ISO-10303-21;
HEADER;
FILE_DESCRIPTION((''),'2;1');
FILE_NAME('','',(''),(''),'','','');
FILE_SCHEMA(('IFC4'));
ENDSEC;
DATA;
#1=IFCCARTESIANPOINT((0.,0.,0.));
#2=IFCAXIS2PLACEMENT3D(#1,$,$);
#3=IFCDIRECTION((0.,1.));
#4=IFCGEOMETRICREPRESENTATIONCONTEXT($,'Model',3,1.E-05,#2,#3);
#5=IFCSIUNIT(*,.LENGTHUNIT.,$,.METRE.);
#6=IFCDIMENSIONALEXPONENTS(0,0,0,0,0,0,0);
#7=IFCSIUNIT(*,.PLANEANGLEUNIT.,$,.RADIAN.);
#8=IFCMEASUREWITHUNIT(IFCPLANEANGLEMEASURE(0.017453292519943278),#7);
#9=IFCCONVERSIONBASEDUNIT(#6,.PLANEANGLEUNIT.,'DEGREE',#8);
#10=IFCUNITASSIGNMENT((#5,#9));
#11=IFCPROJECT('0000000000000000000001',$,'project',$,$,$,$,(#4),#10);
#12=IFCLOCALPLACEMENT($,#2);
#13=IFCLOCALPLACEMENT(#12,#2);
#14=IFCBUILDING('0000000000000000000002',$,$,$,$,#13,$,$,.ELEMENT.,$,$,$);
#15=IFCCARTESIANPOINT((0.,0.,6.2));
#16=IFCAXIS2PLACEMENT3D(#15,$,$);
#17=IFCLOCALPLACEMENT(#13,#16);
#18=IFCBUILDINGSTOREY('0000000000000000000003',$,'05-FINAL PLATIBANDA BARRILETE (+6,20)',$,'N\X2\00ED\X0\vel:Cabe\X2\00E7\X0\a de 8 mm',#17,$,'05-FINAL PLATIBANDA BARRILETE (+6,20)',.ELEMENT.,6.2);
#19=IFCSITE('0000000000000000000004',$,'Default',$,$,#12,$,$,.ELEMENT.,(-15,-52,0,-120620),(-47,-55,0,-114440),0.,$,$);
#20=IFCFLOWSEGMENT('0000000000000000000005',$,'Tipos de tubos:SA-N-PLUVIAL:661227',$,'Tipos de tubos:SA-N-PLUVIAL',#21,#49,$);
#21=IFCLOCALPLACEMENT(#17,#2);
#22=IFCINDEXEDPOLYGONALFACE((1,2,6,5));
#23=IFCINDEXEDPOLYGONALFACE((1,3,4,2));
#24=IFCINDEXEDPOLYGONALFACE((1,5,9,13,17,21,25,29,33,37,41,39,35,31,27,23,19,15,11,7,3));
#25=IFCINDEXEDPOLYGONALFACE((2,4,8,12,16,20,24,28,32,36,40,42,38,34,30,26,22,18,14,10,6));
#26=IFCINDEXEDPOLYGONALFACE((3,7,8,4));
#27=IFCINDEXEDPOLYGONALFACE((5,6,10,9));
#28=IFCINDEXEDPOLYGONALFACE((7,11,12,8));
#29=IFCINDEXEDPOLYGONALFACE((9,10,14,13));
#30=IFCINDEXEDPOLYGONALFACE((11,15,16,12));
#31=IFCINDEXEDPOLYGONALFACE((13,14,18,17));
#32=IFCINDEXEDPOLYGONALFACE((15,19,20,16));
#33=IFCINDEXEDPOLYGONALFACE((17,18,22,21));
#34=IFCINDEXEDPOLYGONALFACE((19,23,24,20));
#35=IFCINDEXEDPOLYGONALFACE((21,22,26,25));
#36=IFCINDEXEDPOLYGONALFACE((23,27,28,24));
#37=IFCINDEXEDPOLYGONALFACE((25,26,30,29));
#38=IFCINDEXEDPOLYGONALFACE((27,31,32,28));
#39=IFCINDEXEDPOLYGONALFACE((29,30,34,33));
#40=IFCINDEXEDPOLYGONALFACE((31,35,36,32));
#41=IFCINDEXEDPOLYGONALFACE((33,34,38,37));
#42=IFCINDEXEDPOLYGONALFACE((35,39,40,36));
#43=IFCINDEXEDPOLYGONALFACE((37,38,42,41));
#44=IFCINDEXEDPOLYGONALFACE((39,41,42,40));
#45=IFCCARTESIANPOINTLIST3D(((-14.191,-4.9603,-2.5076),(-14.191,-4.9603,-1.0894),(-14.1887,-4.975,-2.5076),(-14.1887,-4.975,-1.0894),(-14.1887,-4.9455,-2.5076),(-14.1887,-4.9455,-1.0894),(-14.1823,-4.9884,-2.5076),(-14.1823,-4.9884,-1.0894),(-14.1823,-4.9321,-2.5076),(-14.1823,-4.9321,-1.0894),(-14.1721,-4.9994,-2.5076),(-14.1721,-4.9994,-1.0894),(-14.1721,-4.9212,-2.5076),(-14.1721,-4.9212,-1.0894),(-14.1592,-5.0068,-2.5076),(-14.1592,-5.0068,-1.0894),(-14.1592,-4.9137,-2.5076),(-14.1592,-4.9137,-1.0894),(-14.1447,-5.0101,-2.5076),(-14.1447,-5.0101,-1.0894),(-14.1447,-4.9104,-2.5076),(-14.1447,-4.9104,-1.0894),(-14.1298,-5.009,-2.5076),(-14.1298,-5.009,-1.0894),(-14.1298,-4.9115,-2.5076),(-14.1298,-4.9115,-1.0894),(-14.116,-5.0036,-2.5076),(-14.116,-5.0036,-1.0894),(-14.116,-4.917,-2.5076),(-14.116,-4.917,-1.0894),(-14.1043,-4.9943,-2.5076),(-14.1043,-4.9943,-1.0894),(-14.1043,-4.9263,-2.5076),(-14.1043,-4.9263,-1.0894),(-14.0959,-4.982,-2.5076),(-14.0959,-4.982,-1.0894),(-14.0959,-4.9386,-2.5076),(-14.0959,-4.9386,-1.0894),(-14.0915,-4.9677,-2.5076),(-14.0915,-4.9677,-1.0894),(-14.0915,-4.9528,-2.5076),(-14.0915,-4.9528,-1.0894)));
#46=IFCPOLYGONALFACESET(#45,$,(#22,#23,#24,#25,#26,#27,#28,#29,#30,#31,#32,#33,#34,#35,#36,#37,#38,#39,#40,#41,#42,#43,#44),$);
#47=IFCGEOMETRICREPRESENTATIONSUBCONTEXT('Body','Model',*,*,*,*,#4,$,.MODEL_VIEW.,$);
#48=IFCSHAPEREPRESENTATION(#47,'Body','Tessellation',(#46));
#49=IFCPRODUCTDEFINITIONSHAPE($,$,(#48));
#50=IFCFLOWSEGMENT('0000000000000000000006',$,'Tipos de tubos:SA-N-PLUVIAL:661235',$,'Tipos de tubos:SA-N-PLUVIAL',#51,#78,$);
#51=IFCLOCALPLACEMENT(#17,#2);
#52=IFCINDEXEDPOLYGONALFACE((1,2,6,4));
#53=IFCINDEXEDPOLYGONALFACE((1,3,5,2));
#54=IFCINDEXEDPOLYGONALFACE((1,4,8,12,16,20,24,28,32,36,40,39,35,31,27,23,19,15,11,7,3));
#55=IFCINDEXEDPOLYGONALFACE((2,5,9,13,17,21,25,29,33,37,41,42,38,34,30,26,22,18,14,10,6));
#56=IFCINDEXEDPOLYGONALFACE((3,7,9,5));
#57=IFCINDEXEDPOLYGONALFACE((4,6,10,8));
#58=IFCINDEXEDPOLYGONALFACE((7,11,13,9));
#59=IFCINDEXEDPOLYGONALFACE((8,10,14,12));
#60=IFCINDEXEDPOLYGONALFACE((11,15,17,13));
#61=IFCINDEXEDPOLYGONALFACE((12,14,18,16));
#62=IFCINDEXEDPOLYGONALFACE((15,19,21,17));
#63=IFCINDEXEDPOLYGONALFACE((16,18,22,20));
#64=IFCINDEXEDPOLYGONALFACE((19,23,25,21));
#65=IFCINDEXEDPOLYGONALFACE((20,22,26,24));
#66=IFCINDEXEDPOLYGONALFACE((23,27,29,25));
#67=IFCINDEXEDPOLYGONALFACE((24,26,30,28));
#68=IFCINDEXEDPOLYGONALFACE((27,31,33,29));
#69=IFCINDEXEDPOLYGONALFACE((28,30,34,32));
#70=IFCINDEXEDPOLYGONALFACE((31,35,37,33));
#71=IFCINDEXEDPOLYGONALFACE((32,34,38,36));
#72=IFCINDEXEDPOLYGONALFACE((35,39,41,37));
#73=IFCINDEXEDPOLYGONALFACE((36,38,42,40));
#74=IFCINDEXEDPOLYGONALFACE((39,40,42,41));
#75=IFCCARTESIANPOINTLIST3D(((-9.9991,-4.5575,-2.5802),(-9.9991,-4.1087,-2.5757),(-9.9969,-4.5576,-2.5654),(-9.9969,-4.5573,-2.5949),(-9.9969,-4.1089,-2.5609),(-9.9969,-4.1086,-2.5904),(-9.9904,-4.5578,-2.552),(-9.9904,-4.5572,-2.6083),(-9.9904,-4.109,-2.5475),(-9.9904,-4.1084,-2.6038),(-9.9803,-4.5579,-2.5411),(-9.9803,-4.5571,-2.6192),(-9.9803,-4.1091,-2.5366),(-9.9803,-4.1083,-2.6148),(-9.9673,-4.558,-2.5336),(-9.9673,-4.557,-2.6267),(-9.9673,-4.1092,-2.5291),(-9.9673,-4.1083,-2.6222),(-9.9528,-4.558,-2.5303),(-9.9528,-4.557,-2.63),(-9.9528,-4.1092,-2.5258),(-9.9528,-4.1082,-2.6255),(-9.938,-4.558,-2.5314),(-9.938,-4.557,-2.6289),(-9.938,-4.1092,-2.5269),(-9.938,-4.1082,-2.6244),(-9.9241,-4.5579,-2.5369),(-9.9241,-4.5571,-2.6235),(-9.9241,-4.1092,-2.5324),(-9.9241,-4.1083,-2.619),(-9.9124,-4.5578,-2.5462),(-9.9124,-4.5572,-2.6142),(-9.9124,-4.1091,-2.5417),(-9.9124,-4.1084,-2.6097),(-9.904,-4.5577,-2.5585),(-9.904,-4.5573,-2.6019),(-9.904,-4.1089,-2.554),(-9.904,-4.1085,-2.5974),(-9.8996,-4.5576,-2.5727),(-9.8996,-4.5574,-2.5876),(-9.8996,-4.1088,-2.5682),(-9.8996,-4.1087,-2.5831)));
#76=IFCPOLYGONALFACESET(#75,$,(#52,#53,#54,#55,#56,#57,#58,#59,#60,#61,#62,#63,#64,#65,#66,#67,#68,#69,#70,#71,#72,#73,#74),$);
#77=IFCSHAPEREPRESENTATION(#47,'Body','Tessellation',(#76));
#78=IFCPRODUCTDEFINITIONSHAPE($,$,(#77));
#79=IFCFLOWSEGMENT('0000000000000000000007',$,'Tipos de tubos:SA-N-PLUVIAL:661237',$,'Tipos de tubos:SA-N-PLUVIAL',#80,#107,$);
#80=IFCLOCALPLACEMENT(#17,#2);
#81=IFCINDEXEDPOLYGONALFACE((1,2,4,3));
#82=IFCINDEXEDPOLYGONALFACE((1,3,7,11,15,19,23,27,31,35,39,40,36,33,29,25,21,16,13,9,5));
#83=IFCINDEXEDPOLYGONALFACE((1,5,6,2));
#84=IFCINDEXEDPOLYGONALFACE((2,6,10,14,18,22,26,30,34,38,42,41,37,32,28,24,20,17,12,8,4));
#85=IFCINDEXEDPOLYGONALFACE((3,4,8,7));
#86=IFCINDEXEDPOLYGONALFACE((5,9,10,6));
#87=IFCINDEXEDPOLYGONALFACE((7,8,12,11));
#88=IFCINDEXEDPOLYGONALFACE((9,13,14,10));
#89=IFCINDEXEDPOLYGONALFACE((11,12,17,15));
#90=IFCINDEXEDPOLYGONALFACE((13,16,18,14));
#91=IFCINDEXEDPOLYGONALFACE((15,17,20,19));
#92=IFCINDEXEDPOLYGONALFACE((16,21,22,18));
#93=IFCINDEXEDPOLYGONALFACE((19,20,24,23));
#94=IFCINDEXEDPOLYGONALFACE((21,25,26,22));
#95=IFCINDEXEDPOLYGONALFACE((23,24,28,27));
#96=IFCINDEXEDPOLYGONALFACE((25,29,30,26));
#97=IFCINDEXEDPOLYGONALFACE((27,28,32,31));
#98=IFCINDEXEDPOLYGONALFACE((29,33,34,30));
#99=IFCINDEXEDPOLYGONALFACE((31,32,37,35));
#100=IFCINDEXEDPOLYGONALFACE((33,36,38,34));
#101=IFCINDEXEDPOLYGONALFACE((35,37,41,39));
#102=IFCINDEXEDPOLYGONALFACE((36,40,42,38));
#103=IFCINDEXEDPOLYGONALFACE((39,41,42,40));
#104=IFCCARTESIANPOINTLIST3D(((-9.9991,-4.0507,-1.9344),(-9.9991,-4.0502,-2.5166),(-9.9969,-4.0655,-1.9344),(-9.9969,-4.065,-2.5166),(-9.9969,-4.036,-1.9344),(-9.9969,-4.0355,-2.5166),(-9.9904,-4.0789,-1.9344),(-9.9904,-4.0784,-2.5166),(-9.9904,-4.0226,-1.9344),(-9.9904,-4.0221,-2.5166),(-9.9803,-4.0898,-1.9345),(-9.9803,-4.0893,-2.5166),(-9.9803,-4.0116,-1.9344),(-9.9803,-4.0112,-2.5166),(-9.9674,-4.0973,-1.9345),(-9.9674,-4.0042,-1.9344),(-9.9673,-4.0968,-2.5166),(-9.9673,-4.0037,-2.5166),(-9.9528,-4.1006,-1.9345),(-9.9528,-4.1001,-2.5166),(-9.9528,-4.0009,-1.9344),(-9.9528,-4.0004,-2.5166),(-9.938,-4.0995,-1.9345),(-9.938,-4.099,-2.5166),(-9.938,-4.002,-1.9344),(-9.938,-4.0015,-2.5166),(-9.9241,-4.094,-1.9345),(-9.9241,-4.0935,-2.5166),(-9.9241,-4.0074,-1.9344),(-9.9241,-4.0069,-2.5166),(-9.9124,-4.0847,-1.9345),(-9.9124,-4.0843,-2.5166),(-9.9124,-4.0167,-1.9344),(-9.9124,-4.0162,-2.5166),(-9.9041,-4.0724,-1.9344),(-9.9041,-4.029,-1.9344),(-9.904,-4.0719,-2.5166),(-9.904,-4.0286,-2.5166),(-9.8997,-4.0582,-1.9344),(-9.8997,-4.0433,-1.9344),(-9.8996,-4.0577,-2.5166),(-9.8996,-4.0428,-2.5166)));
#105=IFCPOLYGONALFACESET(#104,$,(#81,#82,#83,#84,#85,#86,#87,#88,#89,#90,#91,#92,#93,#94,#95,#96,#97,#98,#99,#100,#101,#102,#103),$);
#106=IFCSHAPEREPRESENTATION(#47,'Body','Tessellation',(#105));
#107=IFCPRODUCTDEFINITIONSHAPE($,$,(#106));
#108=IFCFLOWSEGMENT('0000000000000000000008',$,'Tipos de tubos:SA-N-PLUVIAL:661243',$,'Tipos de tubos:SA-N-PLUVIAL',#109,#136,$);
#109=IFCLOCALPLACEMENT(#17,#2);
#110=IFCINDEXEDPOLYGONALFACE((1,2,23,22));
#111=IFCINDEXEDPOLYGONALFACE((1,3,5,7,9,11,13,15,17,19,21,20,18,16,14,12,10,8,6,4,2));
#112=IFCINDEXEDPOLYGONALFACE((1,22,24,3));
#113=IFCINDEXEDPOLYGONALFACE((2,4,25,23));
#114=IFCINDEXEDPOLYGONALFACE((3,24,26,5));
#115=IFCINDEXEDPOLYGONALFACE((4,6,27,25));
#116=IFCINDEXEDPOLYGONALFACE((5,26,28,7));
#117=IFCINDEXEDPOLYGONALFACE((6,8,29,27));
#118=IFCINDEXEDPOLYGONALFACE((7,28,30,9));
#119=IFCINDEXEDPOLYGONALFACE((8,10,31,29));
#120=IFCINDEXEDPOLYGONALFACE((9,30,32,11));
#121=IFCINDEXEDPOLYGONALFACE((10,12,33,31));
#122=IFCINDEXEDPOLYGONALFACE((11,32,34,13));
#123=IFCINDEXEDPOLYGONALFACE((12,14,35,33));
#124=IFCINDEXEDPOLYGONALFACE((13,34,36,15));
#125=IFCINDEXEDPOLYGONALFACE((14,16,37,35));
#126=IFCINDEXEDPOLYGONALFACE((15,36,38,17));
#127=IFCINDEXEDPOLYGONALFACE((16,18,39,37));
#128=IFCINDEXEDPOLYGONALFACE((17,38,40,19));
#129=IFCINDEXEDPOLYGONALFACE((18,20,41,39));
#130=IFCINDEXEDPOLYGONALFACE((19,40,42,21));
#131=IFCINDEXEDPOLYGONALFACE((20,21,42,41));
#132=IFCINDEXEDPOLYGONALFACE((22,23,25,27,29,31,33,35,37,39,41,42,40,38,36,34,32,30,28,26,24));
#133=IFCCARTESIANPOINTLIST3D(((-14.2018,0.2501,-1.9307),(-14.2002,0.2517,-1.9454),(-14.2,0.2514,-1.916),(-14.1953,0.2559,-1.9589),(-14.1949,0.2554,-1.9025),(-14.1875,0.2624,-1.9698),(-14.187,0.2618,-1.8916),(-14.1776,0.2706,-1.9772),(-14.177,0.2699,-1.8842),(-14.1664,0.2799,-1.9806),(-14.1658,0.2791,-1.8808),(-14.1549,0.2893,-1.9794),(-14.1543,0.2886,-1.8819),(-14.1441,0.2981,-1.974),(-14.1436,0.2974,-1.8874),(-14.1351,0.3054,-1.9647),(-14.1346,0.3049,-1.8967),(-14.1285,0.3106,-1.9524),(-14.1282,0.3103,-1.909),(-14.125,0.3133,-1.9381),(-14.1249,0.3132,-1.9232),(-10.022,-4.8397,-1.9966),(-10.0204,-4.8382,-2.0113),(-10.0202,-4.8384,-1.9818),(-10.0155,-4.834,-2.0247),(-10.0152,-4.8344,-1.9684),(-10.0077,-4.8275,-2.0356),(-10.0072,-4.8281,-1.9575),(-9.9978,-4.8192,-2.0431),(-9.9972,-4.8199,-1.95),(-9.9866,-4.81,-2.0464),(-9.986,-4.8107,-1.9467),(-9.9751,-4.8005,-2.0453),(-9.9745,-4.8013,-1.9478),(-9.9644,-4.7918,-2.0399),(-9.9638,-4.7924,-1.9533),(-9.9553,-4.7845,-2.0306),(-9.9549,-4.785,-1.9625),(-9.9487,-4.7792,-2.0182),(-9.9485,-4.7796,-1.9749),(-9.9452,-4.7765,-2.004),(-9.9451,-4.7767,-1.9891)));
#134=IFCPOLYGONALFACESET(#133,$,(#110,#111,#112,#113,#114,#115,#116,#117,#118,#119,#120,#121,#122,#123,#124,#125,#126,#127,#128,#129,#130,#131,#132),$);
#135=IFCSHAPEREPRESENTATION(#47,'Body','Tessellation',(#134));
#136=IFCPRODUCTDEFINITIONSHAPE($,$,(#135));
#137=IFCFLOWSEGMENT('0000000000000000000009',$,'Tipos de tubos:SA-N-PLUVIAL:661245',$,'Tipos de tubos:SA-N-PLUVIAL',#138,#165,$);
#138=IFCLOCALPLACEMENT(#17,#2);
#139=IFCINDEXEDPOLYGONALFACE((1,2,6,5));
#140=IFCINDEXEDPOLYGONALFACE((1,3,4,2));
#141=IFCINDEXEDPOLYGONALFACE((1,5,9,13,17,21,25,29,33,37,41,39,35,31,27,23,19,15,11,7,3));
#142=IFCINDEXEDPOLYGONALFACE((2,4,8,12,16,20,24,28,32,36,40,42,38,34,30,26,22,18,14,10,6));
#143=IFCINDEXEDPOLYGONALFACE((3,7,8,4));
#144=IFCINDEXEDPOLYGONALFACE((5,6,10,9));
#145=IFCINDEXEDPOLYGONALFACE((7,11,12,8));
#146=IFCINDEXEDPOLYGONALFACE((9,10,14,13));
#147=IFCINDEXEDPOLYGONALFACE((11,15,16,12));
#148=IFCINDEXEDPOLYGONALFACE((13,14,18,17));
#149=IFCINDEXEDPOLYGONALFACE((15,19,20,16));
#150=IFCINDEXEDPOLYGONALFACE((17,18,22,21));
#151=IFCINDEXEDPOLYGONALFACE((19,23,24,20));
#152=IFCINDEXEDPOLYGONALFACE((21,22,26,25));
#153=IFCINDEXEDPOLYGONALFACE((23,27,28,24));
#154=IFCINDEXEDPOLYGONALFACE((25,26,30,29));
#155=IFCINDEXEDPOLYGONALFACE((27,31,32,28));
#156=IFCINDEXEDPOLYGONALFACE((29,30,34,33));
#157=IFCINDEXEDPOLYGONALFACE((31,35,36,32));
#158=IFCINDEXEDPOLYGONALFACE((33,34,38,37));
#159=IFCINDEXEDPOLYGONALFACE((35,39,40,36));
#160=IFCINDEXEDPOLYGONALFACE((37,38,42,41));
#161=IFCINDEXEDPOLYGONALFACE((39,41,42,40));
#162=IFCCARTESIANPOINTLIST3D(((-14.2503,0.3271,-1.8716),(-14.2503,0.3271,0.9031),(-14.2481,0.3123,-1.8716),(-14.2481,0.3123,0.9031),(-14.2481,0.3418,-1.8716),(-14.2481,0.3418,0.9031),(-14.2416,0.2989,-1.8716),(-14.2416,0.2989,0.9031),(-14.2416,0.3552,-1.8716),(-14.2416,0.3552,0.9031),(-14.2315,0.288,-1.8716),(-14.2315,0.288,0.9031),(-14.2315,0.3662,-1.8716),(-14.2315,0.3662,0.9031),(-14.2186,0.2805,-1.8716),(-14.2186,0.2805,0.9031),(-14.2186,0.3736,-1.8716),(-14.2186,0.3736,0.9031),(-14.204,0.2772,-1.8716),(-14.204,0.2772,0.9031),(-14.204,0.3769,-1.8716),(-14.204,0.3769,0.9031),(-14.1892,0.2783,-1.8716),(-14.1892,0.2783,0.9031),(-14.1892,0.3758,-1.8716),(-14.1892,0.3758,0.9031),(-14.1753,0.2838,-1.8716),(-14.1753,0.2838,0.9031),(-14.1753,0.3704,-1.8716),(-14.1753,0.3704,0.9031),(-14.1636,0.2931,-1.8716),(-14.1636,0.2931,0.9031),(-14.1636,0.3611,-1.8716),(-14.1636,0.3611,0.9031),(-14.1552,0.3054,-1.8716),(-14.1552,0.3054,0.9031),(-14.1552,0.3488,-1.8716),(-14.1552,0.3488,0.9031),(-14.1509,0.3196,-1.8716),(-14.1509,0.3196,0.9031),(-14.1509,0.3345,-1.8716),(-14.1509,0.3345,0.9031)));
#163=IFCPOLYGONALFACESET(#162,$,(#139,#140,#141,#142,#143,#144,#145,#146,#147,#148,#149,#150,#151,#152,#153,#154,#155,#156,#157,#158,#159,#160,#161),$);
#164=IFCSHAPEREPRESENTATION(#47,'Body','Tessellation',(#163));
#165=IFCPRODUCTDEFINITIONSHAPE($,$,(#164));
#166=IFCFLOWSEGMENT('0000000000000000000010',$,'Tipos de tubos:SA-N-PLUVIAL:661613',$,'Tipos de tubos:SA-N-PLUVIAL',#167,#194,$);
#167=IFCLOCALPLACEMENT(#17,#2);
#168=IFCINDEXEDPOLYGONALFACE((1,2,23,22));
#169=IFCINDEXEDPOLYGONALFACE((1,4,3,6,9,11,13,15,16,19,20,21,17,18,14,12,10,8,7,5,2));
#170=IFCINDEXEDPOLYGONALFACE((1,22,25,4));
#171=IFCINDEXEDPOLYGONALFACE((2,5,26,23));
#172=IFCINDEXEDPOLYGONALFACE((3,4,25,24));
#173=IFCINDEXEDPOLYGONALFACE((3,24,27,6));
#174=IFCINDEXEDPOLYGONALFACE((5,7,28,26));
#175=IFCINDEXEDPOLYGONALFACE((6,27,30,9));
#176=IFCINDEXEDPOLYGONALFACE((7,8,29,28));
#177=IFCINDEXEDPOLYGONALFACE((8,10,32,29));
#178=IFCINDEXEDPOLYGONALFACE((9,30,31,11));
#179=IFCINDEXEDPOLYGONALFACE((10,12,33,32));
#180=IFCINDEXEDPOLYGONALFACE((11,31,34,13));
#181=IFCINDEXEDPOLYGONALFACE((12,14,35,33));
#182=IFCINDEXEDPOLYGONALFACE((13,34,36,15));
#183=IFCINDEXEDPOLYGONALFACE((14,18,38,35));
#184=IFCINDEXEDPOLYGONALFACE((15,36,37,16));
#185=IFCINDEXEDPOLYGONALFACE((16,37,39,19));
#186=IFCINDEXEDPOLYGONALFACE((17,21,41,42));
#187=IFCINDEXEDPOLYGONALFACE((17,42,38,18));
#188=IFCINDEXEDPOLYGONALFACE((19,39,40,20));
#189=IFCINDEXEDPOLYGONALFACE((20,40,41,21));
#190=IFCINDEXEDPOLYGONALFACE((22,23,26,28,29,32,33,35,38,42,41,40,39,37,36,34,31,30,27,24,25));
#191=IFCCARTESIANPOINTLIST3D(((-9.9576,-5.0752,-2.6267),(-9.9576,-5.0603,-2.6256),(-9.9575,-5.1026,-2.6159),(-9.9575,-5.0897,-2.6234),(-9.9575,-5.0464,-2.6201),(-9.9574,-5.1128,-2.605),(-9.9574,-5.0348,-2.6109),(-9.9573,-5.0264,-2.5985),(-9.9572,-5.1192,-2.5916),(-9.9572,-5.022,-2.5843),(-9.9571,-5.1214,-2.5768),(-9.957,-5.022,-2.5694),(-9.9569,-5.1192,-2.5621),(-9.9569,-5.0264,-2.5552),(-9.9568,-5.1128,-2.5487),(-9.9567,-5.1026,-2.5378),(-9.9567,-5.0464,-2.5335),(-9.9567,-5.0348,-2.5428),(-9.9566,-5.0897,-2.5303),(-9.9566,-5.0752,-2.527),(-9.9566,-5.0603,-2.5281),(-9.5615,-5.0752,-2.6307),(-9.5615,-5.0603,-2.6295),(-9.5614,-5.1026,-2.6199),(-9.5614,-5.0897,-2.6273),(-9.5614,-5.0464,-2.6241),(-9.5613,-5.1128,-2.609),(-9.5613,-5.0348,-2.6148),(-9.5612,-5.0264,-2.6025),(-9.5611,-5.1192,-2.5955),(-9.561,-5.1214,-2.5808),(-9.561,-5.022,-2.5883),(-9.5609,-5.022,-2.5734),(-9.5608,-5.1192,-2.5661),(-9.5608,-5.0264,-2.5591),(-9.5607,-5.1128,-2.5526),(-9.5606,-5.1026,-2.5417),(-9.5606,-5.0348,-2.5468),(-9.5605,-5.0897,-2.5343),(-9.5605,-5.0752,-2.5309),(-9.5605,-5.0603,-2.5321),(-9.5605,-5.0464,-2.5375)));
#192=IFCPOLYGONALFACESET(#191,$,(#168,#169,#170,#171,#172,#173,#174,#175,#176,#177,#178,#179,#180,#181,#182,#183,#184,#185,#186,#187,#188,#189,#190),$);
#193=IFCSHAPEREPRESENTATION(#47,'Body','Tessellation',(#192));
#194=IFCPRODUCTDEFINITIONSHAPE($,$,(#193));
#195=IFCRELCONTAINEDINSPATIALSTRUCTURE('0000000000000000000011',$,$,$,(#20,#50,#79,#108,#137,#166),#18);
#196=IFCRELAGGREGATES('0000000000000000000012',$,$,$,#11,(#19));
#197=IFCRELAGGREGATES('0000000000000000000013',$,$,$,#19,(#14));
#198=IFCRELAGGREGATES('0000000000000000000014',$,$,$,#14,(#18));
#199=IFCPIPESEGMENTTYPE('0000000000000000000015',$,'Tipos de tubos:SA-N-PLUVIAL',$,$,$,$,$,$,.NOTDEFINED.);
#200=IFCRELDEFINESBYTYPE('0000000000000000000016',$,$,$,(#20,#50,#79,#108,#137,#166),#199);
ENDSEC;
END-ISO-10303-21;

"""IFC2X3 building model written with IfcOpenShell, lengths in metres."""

from ifc_helpers import new_model, entity, si_unit, converted_unit, direction, frame, frame_2d, origin, origin_2d_with_axis, place, context, subcontext, project, spatial, circle, extrude, type_object, element, save


model = new_model("IFC2X3")

# Units and contexts
model_context = context("Model", 3, precision=1e-05, world=origin(), true_north=direction((0.0, 1.0)))
body_context = subcontext(model_context, "Body", "Model", "MODEL_VIEW")
ifc_project = project(units=[si_unit("LENGTHUNIT", "METRE"), converted_unit("PLANEANGLEUNIT", "DEGREE", entity("IfcPlaneAngleMeasure", 0.017453292519943278), si_unit("PLANEANGLEUNIT", "RADIAN"), dimensions=[0, 0, 0, 0, 0, 0, 0])], contexts=[model_context])

# Site, building, storey
site_placement = place(None, origin())
site = spatial("IfcSite", under=ifc_project, at=site_placement, Name="Default", CompositionType="ELEMENT", RefLatitude=(-15, -52, 0, -120620), RefLongitude=(-47, -55, 0, -114440), RefElevation=0.0)
building_placement = place(site_placement, origin())
building = spatial("IfcBuilding", under=site, at=building_placement, CompositionType="ELEMENT")
storey_placement = place(building_placement, frame((0.0, 0.0, 6.2)))
storey = spatial("IfcBuildingStorey", under=building, at=storey_placement, Name="05-FINAL PLATIBANDA BARRILETE (+6,20)", ObjectType="Nível:Cabeça de 8 mm", LongName="05-FINAL PLATIBANDA BARRILETE (+6,20)", CompositionType="ELEMENT", Elevation=6.2)

# Flow segments
pipe_segment_type = type_object("IfcPipeSegmentType", Name="Tipos de tubos:SA-N-PLUVIAL", PredefinedType="NOTDEFINED")
flow_segment_1_placement = place(storey_placement, origin())
element("IfcFlowSegment", 1, at=flow_segment_1_placement, inside=storey, type_object=pipe_segment_type, Name="Tipos de tubos:SA-N-PLUVIAL:661227", ObjectType="Tipos de tubos:SA-N-PLUVIAL", context=body_context, shape_type="SweptSolid", body=[
    extrude(circle(Radius=0.05, at=origin_2d_with_axis()), frame((-14.141, -4.9603, -2.5076), z_axis=(0.0, 0.0, 1.0), x_axis=(-1.0, 0.0, 0.0)), (0.0, 0.0, 1.0), 1.4182),
])
flow_segment_2_placement = place(storey_placement, origin())
element("IfcFlowSegment", 2, at=flow_segment_2_placement, inside=storey, type_object=pipe_segment_type, Name="Tipos de tubos:SA-N-PLUVIAL:661235", ObjectType="Tipos de tubos:SA-N-PLUVIAL", context=body_context, shape_type="SweptSolid", body=[
    extrude(circle(Radius=0.05, at=frame_2d((0.0, 0.0), x_axis=(1.0, 0.0))), frame((-9.9491, -4.5575, -2.5802), z_axis=(-0.000001, 0.99995, 0.01), x_axis=(-1.0, -0.000001, 0.0)), (0.0, 0.0, 1.0), 0.4488),
])
flow_segment_3_placement = place(storey_placement, origin())
element("IfcFlowSegment", 3, at=flow_segment_3_placement, inside=storey, type_object=pipe_segment_type, Name="Tipos de tubos:SA-N-PLUVIAL:661237", ObjectType="Tipos de tubos:SA-N-PLUVIAL", context=body_context, shape_type="SweptSolid", body=[
    extrude(circle(Radius=0.05, at=frame_2d((0.0, 0.0), x_axis=(1.0, 0.0))), frame((-9.9491, -4.0502, -2.5166), z_axis=(-0.000036, -0.00084, 1.0), x_axis=(-1.0, 0.0, -0.000036)), (0.0, 0.0, 1.0), 0.5822),
])
flow_segment_4_placement = place(storey_placement, origin())
element("IfcFlowSegment", 4, at=flow_segment_4_placement, inside=storey, type_object=pipe_segment_type, Name="Tipos de tubos:SA-N-PLUVIAL:661243", ObjectType="Tipos de tubos:SA-N-PLUVIAL", context=body_context, shape_type="SweptSolid", body=[
    extrude(circle(Radius=0.05, at=frame_2d((0.0, 0.0), x_axis=(1.0, 0.0))), frame((-9.9834, -4.808, -1.9966), z_axis=(-0.634602, 0.772775, 0.01), x_axis=(-0.772813, -0.634634, 0.0)), (0.0, 0.0, 1.0), 6.5865),
])
flow_segment_5_placement = place(storey_placement, origin())
element("IfcFlowSegment", 5, at=flow_segment_5_placement, inside=storey, type_object=pipe_segment_type, Name="Tipos de tubos:SA-N-PLUVIAL:661245", ObjectType="Tipos de tubos:SA-N-PLUVIAL", context=body_context, shape_type="SweptSolid", body=[
    extrude(circle(Radius=0.05, at=frame_2d((0.0, 0.0), x_axis=(1.0, 0.0))), frame((-14.2003, 0.3271, -1.8716), z_axis=(0.0, 0.0, 1.0), x_axis=(-1.0, 0.0, 0.0)), (0.0, 0.0, 1.0), 2.7747),
])
flow_segment_6_placement = place(storey_placement, origin())
element("IfcFlowSegment", 6, at=flow_segment_6_placement, inside=storey, type_object=pipe_segment_type, Name="Tipos de tubos:SA-N-PLUVIAL:661613", ObjectType="Tipos de tubos:SA-N-PLUVIAL", context=body_context, shape_type="SweptSolid", body=[
    extrude(circle(Radius=0.05, at=origin_2d_with_axis()), frame((-9.9571, -5.0714, -2.5768), z_axis=(0.99995, 0.000001, -0.01), x_axis=(0.000001, -1.0, 0.0)), (0.0, 0.0, 1.0), 0.3961),
])

save(model, "model.ifc")
